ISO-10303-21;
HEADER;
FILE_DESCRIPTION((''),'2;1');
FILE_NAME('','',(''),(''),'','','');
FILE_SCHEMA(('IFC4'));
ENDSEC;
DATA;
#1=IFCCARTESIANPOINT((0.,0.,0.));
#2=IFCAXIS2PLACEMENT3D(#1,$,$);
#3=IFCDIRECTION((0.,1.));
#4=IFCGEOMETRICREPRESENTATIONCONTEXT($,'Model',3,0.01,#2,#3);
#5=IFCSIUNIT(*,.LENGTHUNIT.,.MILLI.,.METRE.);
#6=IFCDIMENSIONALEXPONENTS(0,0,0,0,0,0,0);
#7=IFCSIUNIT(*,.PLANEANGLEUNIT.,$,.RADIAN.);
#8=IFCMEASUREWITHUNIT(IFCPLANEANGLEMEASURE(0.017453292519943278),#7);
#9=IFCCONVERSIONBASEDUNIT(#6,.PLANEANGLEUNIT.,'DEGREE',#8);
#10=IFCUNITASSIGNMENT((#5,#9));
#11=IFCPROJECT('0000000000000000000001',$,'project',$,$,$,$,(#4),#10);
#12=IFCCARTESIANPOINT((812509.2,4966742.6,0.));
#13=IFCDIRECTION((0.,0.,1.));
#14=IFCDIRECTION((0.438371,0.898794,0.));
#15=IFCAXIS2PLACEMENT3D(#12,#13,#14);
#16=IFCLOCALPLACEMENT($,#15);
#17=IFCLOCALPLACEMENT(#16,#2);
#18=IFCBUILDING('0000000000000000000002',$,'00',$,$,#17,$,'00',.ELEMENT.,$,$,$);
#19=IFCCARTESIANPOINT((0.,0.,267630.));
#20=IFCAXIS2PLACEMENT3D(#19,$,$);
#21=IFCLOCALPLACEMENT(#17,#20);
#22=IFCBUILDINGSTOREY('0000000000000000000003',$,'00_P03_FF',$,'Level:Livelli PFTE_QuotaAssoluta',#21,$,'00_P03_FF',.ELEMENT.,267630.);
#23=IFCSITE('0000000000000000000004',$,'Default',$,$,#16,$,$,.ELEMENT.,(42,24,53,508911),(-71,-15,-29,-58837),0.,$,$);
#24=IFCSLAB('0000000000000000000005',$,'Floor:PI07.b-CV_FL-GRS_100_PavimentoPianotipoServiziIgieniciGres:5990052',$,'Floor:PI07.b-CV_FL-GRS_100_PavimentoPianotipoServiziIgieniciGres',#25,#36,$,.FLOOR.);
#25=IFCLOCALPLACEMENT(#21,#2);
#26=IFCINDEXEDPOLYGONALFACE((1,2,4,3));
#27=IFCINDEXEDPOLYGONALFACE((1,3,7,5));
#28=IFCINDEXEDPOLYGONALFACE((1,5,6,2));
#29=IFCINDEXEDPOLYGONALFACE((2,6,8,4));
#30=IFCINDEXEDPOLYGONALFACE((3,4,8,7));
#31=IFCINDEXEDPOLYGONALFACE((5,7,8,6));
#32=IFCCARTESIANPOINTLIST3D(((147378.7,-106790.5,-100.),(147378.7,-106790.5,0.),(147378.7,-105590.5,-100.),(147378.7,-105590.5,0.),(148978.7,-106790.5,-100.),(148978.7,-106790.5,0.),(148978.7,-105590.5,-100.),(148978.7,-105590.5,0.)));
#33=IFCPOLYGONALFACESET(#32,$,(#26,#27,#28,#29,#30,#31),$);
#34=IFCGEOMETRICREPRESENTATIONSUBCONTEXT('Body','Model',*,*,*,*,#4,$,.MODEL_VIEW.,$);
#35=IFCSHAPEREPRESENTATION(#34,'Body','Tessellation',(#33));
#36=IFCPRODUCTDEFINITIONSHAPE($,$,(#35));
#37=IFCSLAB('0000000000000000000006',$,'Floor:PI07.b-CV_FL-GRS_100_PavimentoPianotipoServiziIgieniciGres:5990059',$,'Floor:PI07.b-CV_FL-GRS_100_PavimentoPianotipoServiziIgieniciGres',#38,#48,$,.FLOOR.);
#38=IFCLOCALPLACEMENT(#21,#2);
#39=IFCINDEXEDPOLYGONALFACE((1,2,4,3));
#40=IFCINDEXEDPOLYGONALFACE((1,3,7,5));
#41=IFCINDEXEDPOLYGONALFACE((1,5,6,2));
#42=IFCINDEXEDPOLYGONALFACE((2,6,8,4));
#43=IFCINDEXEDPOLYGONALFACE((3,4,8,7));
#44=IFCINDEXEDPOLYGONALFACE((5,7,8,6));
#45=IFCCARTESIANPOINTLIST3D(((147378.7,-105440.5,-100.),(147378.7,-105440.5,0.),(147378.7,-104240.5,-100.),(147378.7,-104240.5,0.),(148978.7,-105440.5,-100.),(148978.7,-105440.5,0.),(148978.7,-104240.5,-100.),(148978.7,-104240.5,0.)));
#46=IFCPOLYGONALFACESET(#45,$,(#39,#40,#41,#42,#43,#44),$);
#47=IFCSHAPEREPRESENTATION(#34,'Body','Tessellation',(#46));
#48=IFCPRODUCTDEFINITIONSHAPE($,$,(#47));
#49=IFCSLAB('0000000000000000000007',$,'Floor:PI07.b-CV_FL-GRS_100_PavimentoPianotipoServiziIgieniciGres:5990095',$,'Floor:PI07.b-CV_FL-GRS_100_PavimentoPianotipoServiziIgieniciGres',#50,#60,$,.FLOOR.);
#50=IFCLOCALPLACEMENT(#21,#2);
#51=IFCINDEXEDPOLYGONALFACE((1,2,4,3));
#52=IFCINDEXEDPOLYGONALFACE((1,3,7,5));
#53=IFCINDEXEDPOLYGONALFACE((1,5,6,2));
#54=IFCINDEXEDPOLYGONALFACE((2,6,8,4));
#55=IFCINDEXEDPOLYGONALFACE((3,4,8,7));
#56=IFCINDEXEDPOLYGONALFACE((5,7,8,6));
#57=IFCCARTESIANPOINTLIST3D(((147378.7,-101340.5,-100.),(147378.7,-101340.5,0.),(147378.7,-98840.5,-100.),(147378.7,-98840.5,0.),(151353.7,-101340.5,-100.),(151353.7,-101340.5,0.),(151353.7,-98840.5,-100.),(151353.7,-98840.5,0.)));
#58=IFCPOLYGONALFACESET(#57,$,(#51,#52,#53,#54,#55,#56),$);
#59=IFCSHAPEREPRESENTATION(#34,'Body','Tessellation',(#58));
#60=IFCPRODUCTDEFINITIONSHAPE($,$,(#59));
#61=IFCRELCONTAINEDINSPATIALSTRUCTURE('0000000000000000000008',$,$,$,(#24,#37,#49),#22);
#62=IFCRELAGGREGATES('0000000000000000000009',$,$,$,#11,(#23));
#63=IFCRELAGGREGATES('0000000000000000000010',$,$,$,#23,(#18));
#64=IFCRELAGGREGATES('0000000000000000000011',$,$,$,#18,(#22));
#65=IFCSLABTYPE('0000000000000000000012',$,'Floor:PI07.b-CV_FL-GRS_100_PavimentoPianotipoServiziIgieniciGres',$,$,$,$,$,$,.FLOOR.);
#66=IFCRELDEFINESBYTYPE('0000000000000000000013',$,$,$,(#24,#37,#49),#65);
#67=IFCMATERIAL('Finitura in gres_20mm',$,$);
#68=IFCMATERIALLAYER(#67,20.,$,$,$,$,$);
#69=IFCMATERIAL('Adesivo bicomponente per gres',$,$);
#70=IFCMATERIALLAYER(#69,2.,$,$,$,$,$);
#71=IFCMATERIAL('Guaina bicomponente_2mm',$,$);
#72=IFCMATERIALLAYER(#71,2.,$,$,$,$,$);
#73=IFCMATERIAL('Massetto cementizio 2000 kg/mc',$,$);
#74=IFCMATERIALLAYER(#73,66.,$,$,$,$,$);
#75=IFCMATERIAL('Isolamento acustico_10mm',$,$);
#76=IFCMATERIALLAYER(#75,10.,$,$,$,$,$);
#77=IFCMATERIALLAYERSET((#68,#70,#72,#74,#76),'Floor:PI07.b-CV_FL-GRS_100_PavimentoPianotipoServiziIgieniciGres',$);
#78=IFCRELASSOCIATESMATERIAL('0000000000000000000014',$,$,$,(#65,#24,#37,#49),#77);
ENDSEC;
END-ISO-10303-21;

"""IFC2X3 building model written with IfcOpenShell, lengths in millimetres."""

from ifc_helpers import new_model, entity, si_unit, converted_unit, direction, frame, frame_2d, origin, place, context, subcontext, project, spatial, rectangle, extrude, material, layer, layer_set, layer_usage, type_object, element, save


model = new_model("IFC2X3")

# Units and contexts
model_context = context("Model", 3, precision=0.01, world=origin(), true_north=direction((0.0, 1.0)))
body_context = subcontext(model_context, "Body", "Model", "MODEL_VIEW")
ifc_project = project(units=[si_unit("LENGTHUNIT", "METRE", prefix="MILLI"), converted_unit("PLANEANGLEUNIT", "DEGREE", entity("IfcPlaneAngleMeasure", 0.017453292519943278), si_unit("PLANEANGLEUNIT", "RADIAN"), dimensions=[0, 0, 0, 0, 0, 0, 0])], contexts=[model_context])

# Site, building, storey
site_placement = place(None, frame((812509.2, 4966742.6, 0.0), z_axis=(0.0, 0.0, 1.0), x_axis=(0.438371, 0.898794, 0.0)))
site = spatial("IfcSite", under=ifc_project, at=site_placement, Name="Default", CompositionType="ELEMENT", RefLatitude=(42, 24, 53, 508911), RefLongitude=(-71, -15, -29, -58837), RefElevation=0.0)
building_placement = place(site_placement, origin())
building = spatial("IfcBuilding", under=site, at=building_placement, Name="00", LongName="00", CompositionType="ELEMENT")
storey_placement = place(building_placement, frame((0.0, 0.0, 267630.0)))
storey = spatial("IfcBuildingStorey", under=building, at=storey_placement, Name="00_P03_FF", ObjectType="Level:Livelli PFTE_QuotaAssoluta", LongName="00_P03_FF", CompositionType="ELEMENT", Elevation=267630.0)

# Slabs
ifc_material_1 = material(Name="Massetto cementizio 2000 kg/mc")
ifc_material_2 = material(Name="Isolamento acustico_10mm")
ifc_material_3 = material(Name="Finitura in gres_20mm")
ifc_layer_1 = layer(ifc_material_3, 20.0)
ifc_material_4 = material(Name="Adesivo bicomponente per gres")
ifc_layer_2 = layer(ifc_material_4, 2.0)
ifc_material_5 = material(Name="Guaina bicomponente_2mm")
ifc_layer_3 = layer(ifc_material_5, 2.0)
ifc_layer_4 = layer(ifc_material_1, 66.0)
ifc_layer_5 = layer(ifc_material_2, 10.0)
ifc_layer_set_1 = layer_set([ifc_layer_1, ifc_layer_2, ifc_layer_3, ifc_layer_4, ifc_layer_5], Name="Floor:PI07.b-CV_FL-GRS_100_PavimentoPianotipoServiziIgieniciGres")
slab_type_1 = type_object("IfcSlabType", Name="Floor:PI07.b-CV_FL-GRS_100_PavimentoPianotipoServiziIgieniciGres", PredefinedType="FLOOR", material=ifc_layer_set_1)
ifc_layer_usage_1 = layer_usage(ifc_layer_set_1, "AXIS3", "POSITIVE", 0.0)
slab_1_placement = place(storey_placement, origin())
element("IfcSlab", 1, at=slab_1_placement, inside=storey, type_object=slab_type_1, material=ifc_layer_usage_1, Name="Floor:PI07.b-CV_FL-GRS_100_PavimentoPianotipoServiziIgieniciGres:5990052", ObjectType="Floor:PI07.b-CV_FL-GRS_100_PavimentoPianotipoServiziIgieniciGres", PredefinedType="FLOOR", context=body_context, shape_type="SweptSolid", body=[
    extrude(rectangle(XDim=1200.0, YDim=1600.0, at=frame_2d((0.0, 0.0), x_axis=(1.0, 0.0))), frame((148178.7, -106190.5, 0.0), z_axis=(0.0, 0.0, -1.0), x_axis=(0.0, 1.0, 0.0)), (0.0, 0.0, 1.0), 100.0),
])
ifc_layer_usage_2 = layer_usage(ifc_layer_set_1, "AXIS3", "POSITIVE", 0.0)
slab_2_placement = place(storey_placement, origin())
element("IfcSlab", 2, at=slab_2_placement, inside=storey, type_object=slab_type_1, material=ifc_layer_usage_2, Name="Floor:PI07.b-CV_FL-GRS_100_PavimentoPianotipoServiziIgieniciGres:5990059", ObjectType="Floor:PI07.b-CV_FL-GRS_100_PavimentoPianotipoServiziIgieniciGres", PredefinedType="FLOOR", context=body_context, shape_type="SweptSolid", body=[
    extrude(rectangle(XDim=1200.0, YDim=1600.0, at=frame_2d((0.0, 0.0), x_axis=(1.0, 0.0))), frame((148178.7, -104840.5, 0.0), z_axis=(0.0, 0.0, -1.0), x_axis=(0.0, 1.0, 0.0)), (0.0, 0.0, 1.0), 100.0),
])
ifc_layer_usage_3 = layer_usage(ifc_layer_set_1, "AXIS3", "POSITIVE", 0.0)
slab_3_placement = place(storey_placement, origin())
element("IfcSlab", 3, at=slab_3_placement, inside=storey, type_object=slab_type_1, material=ifc_layer_usage_3, Name="Floor:PI07.b-CV_FL-GRS_100_PavimentoPianotipoServiziIgieniciGres:5990095", ObjectType="Floor:PI07.b-CV_FL-GRS_100_PavimentoPianotipoServiziIgieniciGres", PredefinedType="FLOOR", context=body_context, shape_type="SweptSolid", body=[
    extrude(rectangle(XDim=2500.0, YDim=3975.0, at=frame_2d((0.0, 0.0), x_axis=(1.0, 0.0))), frame((149366.2, -100090.5, 0.0), z_axis=(0.0, 0.0, -1.0), x_axis=(0.0, 1.0, 0.0)), (0.0, 0.0, 1.0), 100.0),
])

save(model, "model.ifc")
